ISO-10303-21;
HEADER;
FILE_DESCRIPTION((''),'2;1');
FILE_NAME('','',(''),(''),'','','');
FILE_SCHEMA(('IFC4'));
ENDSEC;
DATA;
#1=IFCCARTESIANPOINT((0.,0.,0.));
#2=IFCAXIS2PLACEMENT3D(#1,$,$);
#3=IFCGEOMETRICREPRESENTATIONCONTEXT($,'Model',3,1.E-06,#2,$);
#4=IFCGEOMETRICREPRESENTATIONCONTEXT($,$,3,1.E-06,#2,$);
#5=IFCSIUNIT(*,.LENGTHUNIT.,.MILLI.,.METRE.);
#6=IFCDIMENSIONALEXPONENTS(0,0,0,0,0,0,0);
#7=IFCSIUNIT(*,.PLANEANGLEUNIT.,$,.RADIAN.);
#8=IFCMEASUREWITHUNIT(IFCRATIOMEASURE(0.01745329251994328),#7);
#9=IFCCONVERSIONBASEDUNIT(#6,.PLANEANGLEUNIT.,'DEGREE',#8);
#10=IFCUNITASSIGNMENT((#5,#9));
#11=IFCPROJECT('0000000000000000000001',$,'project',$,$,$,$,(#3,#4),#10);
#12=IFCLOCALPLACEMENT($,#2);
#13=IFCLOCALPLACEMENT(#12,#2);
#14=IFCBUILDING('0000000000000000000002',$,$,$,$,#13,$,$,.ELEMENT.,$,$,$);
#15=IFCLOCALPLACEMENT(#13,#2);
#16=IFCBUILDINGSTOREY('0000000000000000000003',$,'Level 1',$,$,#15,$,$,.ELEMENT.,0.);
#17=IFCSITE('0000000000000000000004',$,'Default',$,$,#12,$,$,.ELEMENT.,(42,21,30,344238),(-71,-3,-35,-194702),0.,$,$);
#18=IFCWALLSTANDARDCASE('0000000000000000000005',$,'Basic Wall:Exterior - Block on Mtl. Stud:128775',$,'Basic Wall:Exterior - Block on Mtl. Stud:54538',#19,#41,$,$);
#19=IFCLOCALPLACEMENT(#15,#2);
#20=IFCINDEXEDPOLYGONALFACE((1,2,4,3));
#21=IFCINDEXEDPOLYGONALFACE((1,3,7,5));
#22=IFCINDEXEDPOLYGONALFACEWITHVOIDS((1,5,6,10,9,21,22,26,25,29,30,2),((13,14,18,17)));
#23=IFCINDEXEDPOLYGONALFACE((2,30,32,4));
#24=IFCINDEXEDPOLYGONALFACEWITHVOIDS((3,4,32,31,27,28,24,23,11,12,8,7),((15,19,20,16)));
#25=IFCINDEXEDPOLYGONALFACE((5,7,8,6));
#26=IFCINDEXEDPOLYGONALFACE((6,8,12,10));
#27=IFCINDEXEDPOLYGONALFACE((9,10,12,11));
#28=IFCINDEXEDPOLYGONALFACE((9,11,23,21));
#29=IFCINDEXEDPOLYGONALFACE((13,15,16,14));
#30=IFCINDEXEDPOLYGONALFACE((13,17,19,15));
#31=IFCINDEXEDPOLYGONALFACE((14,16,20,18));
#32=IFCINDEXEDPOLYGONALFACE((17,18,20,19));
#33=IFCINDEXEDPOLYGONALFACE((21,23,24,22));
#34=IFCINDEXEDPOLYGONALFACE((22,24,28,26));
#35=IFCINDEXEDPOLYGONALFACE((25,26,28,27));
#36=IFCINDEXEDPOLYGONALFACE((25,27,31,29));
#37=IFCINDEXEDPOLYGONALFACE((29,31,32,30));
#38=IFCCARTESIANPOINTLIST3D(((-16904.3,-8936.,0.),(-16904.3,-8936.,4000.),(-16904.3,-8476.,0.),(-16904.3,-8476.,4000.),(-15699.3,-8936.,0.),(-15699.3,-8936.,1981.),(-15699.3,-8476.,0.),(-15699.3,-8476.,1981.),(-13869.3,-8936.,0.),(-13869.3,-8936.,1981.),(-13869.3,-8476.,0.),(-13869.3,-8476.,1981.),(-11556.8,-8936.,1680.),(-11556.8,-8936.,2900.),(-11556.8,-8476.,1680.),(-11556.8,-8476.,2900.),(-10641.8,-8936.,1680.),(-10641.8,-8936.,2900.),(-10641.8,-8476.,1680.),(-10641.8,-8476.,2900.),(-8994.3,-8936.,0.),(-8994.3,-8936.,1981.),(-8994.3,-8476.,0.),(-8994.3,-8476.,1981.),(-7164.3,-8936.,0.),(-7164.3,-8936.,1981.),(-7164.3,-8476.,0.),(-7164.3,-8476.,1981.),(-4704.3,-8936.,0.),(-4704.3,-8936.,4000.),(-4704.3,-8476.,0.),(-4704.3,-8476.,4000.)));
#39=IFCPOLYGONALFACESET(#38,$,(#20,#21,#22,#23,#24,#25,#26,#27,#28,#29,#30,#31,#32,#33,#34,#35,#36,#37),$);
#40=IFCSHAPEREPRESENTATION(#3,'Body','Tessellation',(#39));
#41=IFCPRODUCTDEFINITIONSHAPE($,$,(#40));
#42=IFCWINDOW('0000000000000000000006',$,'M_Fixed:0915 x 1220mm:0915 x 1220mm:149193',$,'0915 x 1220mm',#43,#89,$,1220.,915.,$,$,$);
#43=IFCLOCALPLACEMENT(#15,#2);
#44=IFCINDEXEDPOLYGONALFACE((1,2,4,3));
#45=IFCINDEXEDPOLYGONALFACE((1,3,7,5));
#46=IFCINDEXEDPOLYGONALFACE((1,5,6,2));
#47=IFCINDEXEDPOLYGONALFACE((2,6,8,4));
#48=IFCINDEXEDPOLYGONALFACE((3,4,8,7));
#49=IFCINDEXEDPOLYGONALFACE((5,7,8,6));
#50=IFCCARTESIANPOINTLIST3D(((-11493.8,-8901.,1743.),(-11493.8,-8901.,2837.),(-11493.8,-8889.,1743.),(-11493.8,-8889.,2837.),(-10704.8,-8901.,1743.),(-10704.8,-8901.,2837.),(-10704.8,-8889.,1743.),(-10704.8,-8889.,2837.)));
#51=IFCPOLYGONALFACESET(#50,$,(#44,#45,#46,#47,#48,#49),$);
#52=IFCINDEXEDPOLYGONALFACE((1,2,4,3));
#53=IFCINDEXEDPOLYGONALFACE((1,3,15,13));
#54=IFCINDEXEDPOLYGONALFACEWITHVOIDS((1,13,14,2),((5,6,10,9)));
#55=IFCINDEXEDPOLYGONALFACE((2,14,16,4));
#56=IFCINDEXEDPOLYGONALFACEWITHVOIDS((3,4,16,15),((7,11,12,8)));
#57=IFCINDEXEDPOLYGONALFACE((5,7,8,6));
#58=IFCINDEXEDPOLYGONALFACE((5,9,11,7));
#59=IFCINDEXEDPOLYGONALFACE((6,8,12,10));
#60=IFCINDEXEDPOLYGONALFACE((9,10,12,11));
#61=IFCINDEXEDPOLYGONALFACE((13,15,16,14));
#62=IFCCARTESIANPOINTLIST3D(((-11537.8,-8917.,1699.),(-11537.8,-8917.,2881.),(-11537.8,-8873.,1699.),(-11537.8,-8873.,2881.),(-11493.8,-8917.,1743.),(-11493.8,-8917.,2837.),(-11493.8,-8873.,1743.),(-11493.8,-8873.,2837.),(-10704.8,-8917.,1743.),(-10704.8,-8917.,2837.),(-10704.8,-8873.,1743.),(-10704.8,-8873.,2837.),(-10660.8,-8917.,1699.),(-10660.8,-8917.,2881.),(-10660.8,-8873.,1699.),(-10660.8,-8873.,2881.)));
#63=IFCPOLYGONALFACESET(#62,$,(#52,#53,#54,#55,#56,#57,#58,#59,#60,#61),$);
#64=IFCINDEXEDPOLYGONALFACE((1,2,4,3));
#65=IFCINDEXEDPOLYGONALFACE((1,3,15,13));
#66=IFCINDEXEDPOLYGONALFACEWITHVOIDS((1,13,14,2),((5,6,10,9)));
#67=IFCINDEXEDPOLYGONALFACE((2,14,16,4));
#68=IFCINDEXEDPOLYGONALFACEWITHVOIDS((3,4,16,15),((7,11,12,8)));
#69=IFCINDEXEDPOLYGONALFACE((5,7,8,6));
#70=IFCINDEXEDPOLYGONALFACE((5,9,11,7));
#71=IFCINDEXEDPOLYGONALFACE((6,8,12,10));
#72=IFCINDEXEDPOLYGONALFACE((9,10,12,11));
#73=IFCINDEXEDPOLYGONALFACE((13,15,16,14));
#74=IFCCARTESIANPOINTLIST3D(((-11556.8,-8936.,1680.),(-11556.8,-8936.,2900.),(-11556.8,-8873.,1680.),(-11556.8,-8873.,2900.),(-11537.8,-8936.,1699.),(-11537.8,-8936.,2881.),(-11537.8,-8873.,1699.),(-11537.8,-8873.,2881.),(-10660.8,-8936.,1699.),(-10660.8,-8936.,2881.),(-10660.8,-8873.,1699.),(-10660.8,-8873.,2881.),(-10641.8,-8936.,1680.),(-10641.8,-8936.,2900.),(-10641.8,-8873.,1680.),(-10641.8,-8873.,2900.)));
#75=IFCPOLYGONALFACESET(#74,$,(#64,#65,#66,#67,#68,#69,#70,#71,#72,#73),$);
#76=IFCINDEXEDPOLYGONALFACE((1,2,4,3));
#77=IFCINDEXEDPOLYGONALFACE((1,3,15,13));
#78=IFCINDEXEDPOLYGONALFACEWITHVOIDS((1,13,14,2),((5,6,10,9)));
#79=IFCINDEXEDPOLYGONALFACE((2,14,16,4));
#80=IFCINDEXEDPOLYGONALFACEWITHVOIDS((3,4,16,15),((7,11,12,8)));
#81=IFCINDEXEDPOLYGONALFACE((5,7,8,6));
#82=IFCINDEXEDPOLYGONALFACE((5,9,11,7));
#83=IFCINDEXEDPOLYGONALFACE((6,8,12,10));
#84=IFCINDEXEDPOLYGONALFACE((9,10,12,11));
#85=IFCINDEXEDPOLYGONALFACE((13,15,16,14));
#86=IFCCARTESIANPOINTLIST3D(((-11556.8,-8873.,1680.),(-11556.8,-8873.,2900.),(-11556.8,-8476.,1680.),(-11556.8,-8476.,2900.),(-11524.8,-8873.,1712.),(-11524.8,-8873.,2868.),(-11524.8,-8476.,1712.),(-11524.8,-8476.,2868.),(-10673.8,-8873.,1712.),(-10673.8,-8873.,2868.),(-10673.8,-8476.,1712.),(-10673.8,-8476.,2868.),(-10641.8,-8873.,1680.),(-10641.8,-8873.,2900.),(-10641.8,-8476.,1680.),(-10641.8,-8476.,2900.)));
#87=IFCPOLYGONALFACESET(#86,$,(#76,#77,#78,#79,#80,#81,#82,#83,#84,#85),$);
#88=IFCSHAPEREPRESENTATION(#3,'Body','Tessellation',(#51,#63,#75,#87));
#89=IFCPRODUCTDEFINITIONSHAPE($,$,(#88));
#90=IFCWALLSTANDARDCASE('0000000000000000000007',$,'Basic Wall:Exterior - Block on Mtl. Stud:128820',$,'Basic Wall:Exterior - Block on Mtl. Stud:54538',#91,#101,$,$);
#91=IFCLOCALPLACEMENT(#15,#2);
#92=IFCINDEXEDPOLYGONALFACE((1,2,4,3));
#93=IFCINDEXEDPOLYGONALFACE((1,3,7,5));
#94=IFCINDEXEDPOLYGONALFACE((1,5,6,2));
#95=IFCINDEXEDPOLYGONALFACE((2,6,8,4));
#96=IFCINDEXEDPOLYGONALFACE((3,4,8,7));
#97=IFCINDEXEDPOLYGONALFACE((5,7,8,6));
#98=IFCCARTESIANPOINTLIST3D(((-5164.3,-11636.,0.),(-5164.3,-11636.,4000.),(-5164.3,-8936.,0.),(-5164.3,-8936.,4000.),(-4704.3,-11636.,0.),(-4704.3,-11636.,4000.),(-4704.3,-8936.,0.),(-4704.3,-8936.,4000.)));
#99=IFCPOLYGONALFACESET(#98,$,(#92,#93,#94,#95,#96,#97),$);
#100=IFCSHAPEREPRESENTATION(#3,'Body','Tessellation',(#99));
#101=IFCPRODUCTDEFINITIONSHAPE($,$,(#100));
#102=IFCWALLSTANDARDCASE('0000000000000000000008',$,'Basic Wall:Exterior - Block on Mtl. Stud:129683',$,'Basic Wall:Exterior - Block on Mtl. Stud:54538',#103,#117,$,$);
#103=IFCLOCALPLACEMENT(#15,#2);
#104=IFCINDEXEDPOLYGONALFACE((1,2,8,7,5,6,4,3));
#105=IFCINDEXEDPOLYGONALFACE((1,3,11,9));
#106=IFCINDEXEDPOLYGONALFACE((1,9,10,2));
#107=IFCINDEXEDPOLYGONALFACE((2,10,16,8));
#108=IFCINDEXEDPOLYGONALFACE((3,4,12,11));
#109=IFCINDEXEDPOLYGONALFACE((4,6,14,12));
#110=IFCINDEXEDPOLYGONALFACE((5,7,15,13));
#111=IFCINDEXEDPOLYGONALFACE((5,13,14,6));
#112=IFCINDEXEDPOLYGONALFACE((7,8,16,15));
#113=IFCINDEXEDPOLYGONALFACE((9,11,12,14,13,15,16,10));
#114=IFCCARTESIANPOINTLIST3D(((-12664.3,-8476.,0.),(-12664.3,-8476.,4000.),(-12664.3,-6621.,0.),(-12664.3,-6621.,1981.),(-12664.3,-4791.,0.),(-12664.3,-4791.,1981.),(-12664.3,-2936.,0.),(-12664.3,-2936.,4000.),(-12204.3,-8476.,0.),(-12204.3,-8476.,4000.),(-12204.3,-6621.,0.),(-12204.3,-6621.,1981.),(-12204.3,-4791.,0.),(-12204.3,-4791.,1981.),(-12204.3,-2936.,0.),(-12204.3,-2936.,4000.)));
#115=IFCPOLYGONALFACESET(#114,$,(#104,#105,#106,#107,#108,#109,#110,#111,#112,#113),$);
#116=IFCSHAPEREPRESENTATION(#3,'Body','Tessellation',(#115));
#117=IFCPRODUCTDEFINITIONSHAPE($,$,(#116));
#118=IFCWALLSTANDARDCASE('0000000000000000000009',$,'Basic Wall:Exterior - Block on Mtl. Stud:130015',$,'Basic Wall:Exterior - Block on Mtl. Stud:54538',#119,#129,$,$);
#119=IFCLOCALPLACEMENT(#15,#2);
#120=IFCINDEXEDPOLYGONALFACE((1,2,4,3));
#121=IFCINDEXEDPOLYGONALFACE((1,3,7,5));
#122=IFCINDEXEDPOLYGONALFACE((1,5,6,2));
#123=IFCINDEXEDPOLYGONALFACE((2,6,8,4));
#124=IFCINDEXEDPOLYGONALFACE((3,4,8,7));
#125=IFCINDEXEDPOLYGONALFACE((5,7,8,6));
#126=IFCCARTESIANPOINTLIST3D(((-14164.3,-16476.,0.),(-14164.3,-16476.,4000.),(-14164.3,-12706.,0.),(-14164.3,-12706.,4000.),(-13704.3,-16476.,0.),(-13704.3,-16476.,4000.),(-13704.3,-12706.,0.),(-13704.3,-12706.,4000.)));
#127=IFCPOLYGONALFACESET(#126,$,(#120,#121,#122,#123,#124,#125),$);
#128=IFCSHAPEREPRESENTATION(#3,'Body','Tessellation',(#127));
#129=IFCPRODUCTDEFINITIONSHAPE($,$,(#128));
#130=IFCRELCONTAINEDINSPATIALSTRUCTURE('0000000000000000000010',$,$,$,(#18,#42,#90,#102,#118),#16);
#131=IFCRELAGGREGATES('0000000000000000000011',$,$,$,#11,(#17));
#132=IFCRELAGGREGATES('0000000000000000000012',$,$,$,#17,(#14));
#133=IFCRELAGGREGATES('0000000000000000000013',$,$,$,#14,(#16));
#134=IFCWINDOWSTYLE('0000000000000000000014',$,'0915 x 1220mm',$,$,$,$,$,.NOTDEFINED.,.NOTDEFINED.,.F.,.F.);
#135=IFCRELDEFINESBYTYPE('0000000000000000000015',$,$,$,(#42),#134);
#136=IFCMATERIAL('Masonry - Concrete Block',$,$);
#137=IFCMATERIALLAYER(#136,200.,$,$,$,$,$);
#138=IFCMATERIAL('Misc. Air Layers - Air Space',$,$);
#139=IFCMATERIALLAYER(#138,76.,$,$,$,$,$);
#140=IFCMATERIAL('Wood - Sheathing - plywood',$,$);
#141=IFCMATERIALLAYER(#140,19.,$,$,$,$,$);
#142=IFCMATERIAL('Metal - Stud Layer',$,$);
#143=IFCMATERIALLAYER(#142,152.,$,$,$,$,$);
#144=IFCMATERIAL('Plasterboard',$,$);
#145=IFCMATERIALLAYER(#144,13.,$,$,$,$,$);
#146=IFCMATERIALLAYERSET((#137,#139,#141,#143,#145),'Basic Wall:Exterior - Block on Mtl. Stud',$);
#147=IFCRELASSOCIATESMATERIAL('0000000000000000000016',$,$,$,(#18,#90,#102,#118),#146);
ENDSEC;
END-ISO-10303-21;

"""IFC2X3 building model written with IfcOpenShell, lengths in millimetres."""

from ifc_helpers import new_model, entity, si_unit, converted_unit, frame, frame_2d, origin, origin_2d_with_axis, place, context, project, spatial, polyline, rectangle, outline, extrude, source, transform, mapped, material, layer, layer_set, layer_usage, type_object, type_shapes, element, fill, save


model = new_model("IFC2X3")

# Units and contexts
model_context = context("Model", 3, precision=1e-06, world=origin())
context_of_model = context(None, 3, precision=1e-06, world=origin())
ifc_project = project(units=[si_unit("LENGTHUNIT", "METRE", prefix="MILLI"), converted_unit("PLANEANGLEUNIT", "DEGREE", entity("IfcRatioMeasure", 0.01745329251994328), si_unit("PLANEANGLEUNIT", "RADIAN"), dimensions=[0, 0, 0, 0, 0, 0, 0])], contexts=[model_context, context_of_model])

# Site, building, storey
site_placement = place(None, origin())
site = spatial("IfcSite", under=ifc_project, at=site_placement, Name="Default", CompositionType="ELEMENT", RefLatitude=(42, 21, 30, 344238), RefLongitude=(-71, -3, -35, -194702), RefElevation=0.0)
building_placement = place(site_placement, origin())
building = spatial("IfcBuilding", under=site, at=building_placement, CompositionType="ELEMENT")
storey_placement = place(building_placement, origin())
storey = spatial("IfcBuildingStorey", under=building, at=storey_placement, Name="Level 1", CompositionType="ELEMENT", Elevation=0.0)

# Shared definitions
ifc_material_1 = material(Name="Masonry - Concrete Block")
ifc_layer_1 = layer(ifc_material_1, 200.0)
ifc_material_2 = material(Name="Misc. Air Layers - Air Space")
ifc_layer_2 = layer(ifc_material_2, 76.0)
ifc_material_3 = material(Name="Wood - Sheathing - plywood")
ifc_layer_3 = layer(ifc_material_3, 19.0)
ifc_material_4 = material(Name="Metal - Stud Layer")
ifc_layer_4 = layer(ifc_material_4, 152.0)
ifc_material_5 = material(Name="Plasterboard")
ifc_layer_5 = layer(ifc_material_5, 13.0)
ifc_layer_set_1 = layer_set([ifc_layer_1, ifc_layer_2, ifc_layer_3, ifc_layer_4, ifc_layer_5], Name="Basic Wall:Exterior - Block on Mtl. Stud")

# Shared definitions
window_style = type_object("IfcWindowStyle", Name="0915 x 1220mm", ConstructionType="NOTDEFINED", OperationType="NOTDEFINED", ParameterTakesPrecedence=False, Sizeable=False)
shared_shape_1 = source(origin(), model_context, "Body", "SweptSolid", [
    extrude(rectangle(XDim=12.0, YDim=789.0, at=origin_2d_with_axis()), frame((457.5, 419.0, 63.0), z_axis=(0.0, 0.0, 1.0), x_axis=(0.0, -1.0, 0.0)), (0.0, 0.0, 1.0), 1094.0),
    extrude(outline(polyline([(-438.5, -591.0), (438.5, -591.0), (438.5, 591.0), (-438.5, 591.0), (-438.5, -591.0)]), holes=[polyline([(-394.5, -547.0), (-394.5, 547.0), (394.5, 547.0), (394.5, -547.0), (-394.5, -547.0)])]), frame((457.5, 397.0, 610.0), z_axis=(0.0, 1.0, 0.0), x_axis=(1.0, 0.0, 0.0)), (0.0, 0.0, 1.0), 44.0),
    extrude(outline(polyline([(-457.5, -610.0), (457.5, -610.0), (457.5, 610.0), (-457.5, 610.0), (-457.5, -610.0)]), holes=[polyline([(-438.5, -591.0), (-438.5, 591.0), (438.5, 591.0), (438.5, -591.0), (-438.5, -591.0)])]), frame((457.5, 397.0, 610.0), z_axis=(0.0, 1.0, 0.0), x_axis=(1.0, 0.0, 0.0)), (0.0, 0.0, 1.0), 63.0),
    extrude(outline(polyline([(-457.5, -610.0), (457.5, -610.0), (457.5, 610.0), (-457.5, 610.0), (-457.5, -610.0)]), holes=[polyline([(-425.5, -578.0), (-425.5, 578.0), (425.5, 578.0), (425.5, -578.0), (-425.5, -578.0)])]), frame((457.5, 0.0, 610.0), z_axis=(0.0, 1.0, 0.0), x_axis=(1.0, 0.0, 0.0)), (0.0, 0.0, 1.0), 397.0),
])
type_shapes(window_style, [shared_shape_1])

# Wall, openings, window
ifc_layer_usage_1 = layer_usage(ifc_layer_set_1, "AXIS2", "NEGATIVE", 230.0)
wall_1_placement = place(storey_placement, frame((-16904.3, -8706.0, 0.0)))
wall_1 = element("IfcWallStandardCase", 1, at=wall_1_placement, inside=storey, material=ifc_layer_usage_1, Name="Basic Wall:Exterior - Block on Mtl. Stud:128775", ObjectType="Basic Wall:Exterior - Block on Mtl. Stud:54538", context=model_context, shape_type="SweptSolid", body=[
    extrude(rectangle(XDim=12200.0, YDim=460.0, at=frame_2d((6100.0, 0.0), x_axis=(-1.0, 0.0))), origin(), (0.0, 0.0, 1.0), 4000.0),
])
opening_1_placement = place(wall_1_placement, frame((7910.0, -230.0, 0.0)))
element("IfcOpeningElement", 2, at=opening_1_placement, cuts=wall_1, ObjectType="Opening", context=model_context, shape_type="SweptSolid", body=[
    extrude(rectangle(XDim=1981.0, YDim=1830.0, at=frame_2d((990.5, 915.0), x_axis=(1.0, 0.0))), frame((0.0, 0.0, 0.0), z_axis=(0.0, 1.0, 0.0), x_axis=(0.0, 0.0, 1.0)), (0.0, 0.0, 1.0), 460.0),
])
opening_2_placement = place(wall_1_placement, frame((3035.0, 230.0, 0.0)))
element("IfcOpeningElement", 3, at=opening_2_placement, cuts=wall_1, ObjectType="Opening", context=model_context, shape_type="SweptSolid", body=[
    extrude(rectangle(XDim=1981.0, YDim=1830.0, at=frame_2d((990.5, 915.0), x_axis=(1.0, 0.0))), frame((0.0, 0.0, 0.0), z_axis=(0.0, -1.0, 0.0), x_axis=(0.0, 0.0, 1.0)), (0.0, 0.0, 1.0), 460.0),
])
opening_3_placement = place(wall_1_placement, frame((5347.5, -230.0, 1680.0)))
opening_3 = element("IfcOpeningElement", 4, at=opening_3_placement, cuts=wall_1, ObjectType="Opening", context=model_context, shape_type="SweptSolid", body=[
    extrude(rectangle(XDim=1220.0, YDim=915.0, at=frame_2d((610.0, 457.5), x_axis=(1.0, 0.0))), frame((0.0, 0.0, 0.0), z_axis=(0.0, 1.0, 0.0), x_axis=(0.0, 0.0, 1.0)), (0.0, 0.0, 1.0), 460.0),
])
window_1_placement = place(opening_3_placement, frame((915.0, 460.0, 0.0), z_axis=(0.0, 0.0, 1.0), x_axis=(-1.0, 0.0, 0.0)))
window_1 = element("IfcWindow", 5, at=window_1_placement, inside=storey, type_object=window_style, Name="M_Fixed:0915 x 1220mm:0915 x 1220mm:149193", ObjectType="0915 x 1220mm", OverallHeight=1220.0, OverallWidth=915.0, context=model_context, shape_type="MappedRepresentation", body=[
    mapped(shared_shape_1, transform((0.0, 0.0, 0.0), scale=1.0)),
])
fill(opening_3, window_1)

# Wall
ifc_layer_usage_2 = layer_usage(ifc_layer_set_1, "AXIS2", "NEGATIVE", 230.0)
wall_2_placement = place(storey_placement, frame((-4934.3, -8936.0, 0.0), z_axis=(0.0, 0.0, 1.0), x_axis=(0.0, -1.0, 0.0)))
element("IfcWallStandardCase", 6, at=wall_2_placement, inside=storey, material=ifc_layer_usage_2, Name="Basic Wall:Exterior - Block on Mtl. Stud:128820", ObjectType="Basic Wall:Exterior - Block on Mtl. Stud:54538", context=model_context, shape_type="SweptSolid", body=[
    extrude(rectangle(XDim=2700.0, YDim=460.0, at=frame_2d((1350.0, 0.0), x_axis=(-1.0, 0.0))), origin(), (0.0, 0.0, 1.0), 4000.0),
])

# Wall, opening
ifc_layer_usage_3 = layer_usage(ifc_layer_set_1, "AXIS2", "NEGATIVE", 230.0)
wall_3_placement = place(storey_placement, frame((-12434.3, -2936.0, 0.0), z_axis=(0.0, 0.0, 1.0), x_axis=(0.0, -1.0, 0.0)))
wall_3 = element("IfcWallStandardCase", 7, at=wall_3_placement, inside=storey, material=ifc_layer_usage_3, Name="Basic Wall:Exterior - Block on Mtl. Stud:129683", ObjectType="Basic Wall:Exterior - Block on Mtl. Stud:54538", context=model_context, shape_type="SweptSolid", body=[
    extrude(rectangle(XDim=5540.0, YDim=460.0, at=frame_2d((2770.0, 0.0), x_axis=(-1.0, 0.0))), origin(), (0.0, 0.0, 1.0), 4000.0),
])
opening_4_placement = place(wall_3_placement, frame((1855.0, -230.0, 0.0)))
element("IfcOpeningElement", 8, at=opening_4_placement, cuts=wall_3, ObjectType="Opening", context=model_context, shape_type="SweptSolid", body=[
    extrude(rectangle(XDim=1981.0, YDim=1830.0, at=frame_2d((990.5, 915.0), x_axis=(1.0, 0.0))), frame((0.0, 0.0, 0.0), z_axis=(0.0, 1.0, 0.0), x_axis=(0.0, 0.0, 1.0)), (0.0, 0.0, 1.0), 460.0),
])

# Wall
ifc_layer_usage_4 = layer_usage(ifc_layer_set_1, "AXIS2", "NEGATIVE", 230.0)
wall_4_placement = place(storey_placement, frame((-13934.3, -16476.0, 0.0), z_axis=(0.0, 0.0, 1.0), x_axis=(0.0, 1.0, 0.0)))
element("IfcWallStandardCase", 9, at=wall_4_placement, inside=storey, material=ifc_layer_usage_4, Name="Basic Wall:Exterior - Block on Mtl. Stud:130015", ObjectType="Basic Wall:Exterior - Block on Mtl. Stud:54538", context=model_context, shape_type="SweptSolid", body=[
    extrude(rectangle(XDim=3770.0, YDim=460.0, at=frame_2d((1885.0, 0.0), x_axis=(-1.0, 0.0))), origin(), (0.0, 0.0, 1.0), 4000.0),
])

save(model, "model.ifc")
